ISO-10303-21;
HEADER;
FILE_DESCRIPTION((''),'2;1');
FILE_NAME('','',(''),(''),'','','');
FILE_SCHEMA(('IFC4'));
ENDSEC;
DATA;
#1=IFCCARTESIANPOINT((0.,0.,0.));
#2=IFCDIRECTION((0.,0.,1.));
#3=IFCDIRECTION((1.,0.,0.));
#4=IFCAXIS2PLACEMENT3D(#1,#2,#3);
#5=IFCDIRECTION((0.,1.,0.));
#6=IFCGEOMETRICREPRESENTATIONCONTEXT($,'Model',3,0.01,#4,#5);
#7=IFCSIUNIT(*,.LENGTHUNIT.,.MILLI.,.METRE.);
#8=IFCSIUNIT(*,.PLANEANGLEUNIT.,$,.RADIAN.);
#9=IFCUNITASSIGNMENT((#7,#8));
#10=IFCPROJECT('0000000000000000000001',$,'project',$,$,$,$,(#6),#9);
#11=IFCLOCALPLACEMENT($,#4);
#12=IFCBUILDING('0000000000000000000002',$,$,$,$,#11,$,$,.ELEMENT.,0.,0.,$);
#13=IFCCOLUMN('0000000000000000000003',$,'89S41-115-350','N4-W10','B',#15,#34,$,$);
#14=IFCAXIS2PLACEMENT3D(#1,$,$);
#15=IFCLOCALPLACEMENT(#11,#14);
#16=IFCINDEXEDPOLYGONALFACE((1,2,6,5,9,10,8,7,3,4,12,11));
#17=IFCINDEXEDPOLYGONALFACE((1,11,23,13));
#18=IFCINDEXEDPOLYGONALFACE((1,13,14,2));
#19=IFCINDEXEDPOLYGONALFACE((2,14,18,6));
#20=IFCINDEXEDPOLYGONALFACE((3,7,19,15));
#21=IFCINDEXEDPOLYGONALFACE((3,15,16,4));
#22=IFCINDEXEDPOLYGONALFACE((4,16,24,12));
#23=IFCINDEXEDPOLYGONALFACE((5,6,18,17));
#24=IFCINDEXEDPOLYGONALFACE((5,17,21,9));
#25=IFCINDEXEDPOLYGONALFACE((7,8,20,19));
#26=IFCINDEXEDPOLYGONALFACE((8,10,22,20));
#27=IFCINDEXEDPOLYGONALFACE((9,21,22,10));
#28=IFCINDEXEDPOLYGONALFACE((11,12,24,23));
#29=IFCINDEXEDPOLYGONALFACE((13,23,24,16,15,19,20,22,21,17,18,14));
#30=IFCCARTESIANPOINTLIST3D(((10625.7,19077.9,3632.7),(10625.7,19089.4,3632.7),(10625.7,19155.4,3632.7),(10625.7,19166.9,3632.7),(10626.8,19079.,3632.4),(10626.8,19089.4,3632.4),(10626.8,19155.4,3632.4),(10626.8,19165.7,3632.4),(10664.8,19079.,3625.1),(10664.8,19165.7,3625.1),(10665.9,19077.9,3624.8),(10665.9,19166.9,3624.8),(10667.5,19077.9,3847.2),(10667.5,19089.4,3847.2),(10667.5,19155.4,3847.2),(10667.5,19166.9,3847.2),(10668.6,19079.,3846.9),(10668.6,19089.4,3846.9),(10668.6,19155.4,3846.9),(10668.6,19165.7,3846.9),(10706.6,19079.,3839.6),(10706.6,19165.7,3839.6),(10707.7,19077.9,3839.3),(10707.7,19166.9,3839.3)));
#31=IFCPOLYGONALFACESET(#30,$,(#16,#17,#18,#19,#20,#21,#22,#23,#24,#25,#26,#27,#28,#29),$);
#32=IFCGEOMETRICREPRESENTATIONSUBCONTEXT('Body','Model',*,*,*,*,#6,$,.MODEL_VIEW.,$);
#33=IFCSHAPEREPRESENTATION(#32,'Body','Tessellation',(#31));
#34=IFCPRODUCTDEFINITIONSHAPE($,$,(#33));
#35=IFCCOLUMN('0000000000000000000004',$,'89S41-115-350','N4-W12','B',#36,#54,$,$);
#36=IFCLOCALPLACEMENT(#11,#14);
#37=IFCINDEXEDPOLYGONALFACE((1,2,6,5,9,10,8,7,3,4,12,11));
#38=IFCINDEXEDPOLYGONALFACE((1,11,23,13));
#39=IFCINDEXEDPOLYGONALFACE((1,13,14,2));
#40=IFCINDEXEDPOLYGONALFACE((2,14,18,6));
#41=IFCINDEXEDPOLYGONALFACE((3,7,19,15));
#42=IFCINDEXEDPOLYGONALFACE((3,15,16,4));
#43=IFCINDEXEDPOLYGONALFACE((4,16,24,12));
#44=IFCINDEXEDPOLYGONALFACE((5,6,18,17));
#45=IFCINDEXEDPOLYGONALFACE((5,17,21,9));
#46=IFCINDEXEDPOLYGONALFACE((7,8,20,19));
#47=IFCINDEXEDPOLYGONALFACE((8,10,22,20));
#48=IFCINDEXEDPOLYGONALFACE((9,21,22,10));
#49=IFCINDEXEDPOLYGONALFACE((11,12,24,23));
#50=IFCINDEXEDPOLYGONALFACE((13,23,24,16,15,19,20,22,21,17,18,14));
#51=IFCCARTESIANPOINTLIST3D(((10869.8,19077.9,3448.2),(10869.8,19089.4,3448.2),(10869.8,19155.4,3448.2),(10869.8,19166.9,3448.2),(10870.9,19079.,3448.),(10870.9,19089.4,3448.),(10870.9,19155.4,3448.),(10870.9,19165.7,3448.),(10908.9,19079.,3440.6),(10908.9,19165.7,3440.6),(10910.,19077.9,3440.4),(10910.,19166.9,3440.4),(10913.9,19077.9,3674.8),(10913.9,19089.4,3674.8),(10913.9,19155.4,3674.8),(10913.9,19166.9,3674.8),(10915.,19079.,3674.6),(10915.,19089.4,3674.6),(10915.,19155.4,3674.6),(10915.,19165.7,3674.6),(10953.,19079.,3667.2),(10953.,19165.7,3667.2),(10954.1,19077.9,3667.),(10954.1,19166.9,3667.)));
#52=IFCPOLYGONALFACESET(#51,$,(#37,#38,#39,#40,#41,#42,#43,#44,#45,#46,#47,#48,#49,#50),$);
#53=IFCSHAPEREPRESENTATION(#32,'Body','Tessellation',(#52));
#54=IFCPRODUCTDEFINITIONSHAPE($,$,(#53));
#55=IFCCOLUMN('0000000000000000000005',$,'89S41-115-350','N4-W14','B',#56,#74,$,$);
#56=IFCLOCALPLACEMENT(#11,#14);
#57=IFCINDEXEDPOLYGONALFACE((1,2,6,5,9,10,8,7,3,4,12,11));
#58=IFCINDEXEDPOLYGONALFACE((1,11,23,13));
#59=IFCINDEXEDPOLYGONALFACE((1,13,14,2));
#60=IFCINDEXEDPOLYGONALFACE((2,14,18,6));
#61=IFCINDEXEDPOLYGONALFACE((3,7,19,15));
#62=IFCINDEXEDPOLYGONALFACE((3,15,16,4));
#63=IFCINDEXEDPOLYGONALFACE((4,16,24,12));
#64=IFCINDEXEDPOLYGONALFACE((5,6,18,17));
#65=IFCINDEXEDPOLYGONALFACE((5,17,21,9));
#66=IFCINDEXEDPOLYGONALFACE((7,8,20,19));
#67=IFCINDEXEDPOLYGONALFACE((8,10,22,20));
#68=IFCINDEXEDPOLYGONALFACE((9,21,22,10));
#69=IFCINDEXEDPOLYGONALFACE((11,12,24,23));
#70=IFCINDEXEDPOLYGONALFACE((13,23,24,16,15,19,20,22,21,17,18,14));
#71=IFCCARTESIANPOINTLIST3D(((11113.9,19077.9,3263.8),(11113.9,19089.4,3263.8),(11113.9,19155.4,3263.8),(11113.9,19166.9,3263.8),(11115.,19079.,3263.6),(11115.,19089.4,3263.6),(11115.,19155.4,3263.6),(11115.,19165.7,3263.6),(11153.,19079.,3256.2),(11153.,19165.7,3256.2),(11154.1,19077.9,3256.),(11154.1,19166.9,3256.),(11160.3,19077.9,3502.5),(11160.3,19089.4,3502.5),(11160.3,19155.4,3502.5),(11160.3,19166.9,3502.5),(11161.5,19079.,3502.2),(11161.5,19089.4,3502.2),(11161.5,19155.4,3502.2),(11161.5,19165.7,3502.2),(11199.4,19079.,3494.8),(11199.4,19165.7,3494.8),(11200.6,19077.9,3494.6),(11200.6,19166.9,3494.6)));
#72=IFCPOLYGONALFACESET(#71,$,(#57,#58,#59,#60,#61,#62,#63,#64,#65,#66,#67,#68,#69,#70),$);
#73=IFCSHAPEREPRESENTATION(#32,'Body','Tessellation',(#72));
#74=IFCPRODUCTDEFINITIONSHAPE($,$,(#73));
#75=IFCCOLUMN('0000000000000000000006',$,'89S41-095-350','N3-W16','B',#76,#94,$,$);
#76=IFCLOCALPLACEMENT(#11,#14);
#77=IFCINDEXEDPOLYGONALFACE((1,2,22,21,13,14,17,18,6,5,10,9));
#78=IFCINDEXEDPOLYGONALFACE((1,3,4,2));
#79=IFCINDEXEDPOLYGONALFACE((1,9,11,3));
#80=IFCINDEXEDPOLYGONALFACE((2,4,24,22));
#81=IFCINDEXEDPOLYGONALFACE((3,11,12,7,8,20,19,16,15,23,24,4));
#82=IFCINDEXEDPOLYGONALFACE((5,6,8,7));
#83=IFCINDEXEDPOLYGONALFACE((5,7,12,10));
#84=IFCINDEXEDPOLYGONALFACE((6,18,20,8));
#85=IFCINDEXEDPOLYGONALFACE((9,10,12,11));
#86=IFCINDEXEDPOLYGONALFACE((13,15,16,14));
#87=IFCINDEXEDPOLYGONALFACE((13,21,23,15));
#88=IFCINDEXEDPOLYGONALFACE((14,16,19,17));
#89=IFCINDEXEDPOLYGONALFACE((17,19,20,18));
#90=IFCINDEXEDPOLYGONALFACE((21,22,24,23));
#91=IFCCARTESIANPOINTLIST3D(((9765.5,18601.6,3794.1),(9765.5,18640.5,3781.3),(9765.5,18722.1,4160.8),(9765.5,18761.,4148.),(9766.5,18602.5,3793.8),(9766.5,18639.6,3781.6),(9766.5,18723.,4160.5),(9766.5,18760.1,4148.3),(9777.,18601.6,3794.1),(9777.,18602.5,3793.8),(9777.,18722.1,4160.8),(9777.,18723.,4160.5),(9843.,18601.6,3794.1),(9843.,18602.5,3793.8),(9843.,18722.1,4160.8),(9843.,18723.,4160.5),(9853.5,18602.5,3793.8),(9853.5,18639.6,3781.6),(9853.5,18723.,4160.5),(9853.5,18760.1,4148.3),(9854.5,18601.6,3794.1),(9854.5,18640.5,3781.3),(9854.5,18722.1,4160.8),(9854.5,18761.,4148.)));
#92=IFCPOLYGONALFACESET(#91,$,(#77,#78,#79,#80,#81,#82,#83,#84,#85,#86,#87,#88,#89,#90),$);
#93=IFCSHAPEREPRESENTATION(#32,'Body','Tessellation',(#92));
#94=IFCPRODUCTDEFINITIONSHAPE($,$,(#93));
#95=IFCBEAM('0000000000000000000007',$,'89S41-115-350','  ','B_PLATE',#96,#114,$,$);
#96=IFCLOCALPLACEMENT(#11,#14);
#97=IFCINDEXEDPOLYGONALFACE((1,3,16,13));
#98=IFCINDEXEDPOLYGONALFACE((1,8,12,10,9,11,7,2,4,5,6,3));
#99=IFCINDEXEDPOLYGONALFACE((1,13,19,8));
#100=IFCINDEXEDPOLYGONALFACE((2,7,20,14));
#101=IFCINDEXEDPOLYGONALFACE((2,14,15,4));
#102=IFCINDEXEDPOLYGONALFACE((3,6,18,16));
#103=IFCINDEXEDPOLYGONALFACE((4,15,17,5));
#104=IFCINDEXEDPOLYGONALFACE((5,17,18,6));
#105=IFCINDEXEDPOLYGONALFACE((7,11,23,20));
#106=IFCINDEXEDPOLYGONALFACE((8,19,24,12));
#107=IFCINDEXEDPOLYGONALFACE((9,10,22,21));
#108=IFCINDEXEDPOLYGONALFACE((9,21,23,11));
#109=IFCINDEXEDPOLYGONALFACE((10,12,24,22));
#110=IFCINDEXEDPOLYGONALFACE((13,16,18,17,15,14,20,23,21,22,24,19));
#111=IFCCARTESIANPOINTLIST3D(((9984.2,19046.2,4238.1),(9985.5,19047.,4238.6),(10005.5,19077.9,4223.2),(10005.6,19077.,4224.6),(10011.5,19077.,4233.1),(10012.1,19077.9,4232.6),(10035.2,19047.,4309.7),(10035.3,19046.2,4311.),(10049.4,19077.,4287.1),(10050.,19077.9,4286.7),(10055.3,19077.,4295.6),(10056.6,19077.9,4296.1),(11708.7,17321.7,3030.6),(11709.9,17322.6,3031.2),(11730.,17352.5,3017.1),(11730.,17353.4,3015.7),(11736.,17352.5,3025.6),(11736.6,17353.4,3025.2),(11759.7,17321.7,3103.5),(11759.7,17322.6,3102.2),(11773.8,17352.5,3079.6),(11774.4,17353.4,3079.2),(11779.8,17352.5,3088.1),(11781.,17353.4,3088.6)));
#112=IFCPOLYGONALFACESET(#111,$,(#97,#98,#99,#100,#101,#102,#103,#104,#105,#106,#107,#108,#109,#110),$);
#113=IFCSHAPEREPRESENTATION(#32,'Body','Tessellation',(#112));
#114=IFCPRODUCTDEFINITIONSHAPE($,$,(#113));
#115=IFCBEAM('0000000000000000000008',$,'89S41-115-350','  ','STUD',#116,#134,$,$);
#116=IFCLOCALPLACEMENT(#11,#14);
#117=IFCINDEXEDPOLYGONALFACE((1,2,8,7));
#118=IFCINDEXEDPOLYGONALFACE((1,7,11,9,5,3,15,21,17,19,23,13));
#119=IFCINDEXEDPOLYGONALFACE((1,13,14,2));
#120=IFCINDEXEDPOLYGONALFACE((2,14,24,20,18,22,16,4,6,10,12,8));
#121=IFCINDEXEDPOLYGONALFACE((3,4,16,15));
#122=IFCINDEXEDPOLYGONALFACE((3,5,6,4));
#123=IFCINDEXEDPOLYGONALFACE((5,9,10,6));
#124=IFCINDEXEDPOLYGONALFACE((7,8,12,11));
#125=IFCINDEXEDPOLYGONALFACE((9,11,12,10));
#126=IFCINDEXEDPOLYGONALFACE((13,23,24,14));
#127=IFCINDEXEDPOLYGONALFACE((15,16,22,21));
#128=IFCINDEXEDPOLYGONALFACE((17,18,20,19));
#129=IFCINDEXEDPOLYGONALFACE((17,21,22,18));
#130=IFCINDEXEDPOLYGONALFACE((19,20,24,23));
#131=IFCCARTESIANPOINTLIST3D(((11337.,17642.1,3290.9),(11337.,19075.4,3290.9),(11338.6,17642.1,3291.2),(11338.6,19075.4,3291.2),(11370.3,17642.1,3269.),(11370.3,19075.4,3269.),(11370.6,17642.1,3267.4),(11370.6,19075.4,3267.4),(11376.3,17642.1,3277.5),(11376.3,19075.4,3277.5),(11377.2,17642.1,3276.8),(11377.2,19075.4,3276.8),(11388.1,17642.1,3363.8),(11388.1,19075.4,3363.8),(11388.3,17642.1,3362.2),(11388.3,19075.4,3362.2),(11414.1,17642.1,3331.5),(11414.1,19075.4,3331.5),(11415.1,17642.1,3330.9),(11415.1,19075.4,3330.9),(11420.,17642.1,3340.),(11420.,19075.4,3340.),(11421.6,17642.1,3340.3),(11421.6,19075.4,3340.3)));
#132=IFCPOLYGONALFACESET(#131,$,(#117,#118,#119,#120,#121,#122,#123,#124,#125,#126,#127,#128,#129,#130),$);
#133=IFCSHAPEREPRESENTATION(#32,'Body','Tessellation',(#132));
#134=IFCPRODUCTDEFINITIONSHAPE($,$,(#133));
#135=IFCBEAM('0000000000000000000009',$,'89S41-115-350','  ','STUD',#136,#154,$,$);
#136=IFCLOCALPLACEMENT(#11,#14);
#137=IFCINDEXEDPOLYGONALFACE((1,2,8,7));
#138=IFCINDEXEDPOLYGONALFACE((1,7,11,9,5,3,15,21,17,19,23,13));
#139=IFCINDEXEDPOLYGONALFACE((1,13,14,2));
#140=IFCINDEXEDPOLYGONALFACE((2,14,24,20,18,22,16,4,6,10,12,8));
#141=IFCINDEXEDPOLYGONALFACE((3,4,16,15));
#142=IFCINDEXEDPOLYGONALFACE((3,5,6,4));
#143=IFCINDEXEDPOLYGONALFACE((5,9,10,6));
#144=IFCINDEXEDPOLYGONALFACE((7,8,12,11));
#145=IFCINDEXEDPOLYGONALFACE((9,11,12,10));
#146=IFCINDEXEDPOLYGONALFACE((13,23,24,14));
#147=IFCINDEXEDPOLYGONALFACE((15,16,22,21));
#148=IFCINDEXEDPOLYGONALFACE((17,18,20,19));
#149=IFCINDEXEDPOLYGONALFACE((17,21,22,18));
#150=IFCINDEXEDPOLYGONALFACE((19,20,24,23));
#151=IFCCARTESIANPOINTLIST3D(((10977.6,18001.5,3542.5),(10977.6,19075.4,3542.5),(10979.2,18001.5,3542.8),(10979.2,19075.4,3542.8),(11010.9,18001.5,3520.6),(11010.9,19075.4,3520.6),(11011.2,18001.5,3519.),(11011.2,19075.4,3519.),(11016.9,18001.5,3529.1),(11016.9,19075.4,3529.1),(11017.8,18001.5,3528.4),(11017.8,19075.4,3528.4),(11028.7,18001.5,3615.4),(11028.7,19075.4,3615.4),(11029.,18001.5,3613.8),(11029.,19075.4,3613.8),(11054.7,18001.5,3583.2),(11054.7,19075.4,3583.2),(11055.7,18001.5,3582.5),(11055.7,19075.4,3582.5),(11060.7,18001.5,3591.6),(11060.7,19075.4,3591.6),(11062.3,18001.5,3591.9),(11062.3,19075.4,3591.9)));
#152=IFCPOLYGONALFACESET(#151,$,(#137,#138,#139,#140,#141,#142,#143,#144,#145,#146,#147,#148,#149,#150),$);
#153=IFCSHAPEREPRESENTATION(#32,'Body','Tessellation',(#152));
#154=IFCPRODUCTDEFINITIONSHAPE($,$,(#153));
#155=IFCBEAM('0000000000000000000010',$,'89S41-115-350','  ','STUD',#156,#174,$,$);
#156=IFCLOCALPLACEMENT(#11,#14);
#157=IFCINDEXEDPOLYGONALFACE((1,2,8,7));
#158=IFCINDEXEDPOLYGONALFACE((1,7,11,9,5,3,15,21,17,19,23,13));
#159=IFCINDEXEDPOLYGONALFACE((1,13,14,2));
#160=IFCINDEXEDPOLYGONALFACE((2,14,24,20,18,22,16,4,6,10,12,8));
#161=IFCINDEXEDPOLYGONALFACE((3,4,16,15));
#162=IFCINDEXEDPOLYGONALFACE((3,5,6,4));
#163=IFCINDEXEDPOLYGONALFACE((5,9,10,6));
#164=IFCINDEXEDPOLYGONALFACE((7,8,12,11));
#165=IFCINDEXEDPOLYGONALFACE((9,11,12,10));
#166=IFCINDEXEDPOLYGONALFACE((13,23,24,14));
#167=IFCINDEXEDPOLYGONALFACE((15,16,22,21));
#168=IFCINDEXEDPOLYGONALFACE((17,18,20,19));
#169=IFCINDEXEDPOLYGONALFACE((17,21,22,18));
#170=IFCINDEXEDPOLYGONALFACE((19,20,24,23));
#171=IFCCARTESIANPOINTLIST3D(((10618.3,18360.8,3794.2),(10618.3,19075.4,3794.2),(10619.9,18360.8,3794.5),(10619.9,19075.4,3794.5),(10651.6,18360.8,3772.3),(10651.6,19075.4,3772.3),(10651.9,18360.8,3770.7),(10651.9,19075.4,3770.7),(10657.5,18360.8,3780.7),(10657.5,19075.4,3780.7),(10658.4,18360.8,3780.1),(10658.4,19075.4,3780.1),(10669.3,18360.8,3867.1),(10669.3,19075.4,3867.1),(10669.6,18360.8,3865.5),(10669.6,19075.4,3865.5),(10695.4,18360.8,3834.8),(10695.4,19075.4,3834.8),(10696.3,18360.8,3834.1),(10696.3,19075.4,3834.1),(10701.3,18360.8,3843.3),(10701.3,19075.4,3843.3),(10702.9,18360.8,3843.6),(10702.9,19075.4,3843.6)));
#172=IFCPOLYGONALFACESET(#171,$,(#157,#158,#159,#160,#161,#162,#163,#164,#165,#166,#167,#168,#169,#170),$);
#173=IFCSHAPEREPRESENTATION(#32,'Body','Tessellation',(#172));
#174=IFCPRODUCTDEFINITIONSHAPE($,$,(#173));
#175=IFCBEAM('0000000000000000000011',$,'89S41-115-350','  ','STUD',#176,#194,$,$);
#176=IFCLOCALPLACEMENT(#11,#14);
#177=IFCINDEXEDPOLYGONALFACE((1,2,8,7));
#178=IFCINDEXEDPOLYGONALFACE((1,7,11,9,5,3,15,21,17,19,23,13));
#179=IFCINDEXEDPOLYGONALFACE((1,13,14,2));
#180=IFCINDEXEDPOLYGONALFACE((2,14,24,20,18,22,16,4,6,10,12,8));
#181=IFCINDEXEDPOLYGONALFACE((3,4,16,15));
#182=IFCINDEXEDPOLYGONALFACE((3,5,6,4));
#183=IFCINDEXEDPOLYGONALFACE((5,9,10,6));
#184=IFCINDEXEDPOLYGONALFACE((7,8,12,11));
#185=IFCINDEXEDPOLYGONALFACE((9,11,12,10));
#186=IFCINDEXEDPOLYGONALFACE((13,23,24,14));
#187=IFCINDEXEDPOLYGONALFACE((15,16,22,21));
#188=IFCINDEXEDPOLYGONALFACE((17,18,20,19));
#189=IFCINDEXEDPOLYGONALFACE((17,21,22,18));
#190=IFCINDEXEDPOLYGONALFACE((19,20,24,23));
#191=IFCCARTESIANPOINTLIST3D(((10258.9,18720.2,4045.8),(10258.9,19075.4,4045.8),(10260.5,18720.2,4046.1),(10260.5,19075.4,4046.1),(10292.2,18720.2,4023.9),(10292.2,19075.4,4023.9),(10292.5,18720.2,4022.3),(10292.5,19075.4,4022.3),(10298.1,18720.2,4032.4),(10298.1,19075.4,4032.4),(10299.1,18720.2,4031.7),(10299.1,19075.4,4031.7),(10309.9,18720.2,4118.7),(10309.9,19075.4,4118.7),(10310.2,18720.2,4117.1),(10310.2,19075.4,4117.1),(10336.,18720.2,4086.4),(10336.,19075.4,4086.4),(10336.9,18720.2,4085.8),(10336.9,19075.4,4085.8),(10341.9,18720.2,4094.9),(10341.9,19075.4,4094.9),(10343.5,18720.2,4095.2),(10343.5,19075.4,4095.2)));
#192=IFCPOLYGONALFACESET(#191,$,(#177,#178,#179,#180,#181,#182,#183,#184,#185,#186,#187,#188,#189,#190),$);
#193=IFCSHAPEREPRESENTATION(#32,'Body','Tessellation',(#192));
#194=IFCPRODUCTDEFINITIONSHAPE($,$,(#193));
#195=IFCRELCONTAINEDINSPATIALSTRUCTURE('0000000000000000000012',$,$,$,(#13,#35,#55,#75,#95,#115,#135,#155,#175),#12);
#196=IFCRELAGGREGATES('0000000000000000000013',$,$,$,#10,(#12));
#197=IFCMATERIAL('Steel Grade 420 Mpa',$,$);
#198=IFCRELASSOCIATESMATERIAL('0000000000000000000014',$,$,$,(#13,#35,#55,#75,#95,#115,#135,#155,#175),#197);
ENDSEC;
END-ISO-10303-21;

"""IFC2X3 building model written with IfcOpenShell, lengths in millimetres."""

from ifc_helpers import new_model, si_unit, direction, frame, origin, origin_with_axes, origin_2d_with_axis, place, context, subcontext, project, spatial, c_section, extrude, source, transform, mapped, material, element, save


model = new_model("IFC2X3")

# Units and contexts
model_context = context("Model", 3, precision=0.01, world=origin_with_axes(), true_north=direction((0.0, 1.0, 0.0)))
body_context = subcontext(model_context, "Body", "Model", "MODEL_VIEW")
ifc_project = project(units=[si_unit("LENGTHUNIT", "METRE", prefix="MILLI"), si_unit("PLANEANGLEUNIT", "RADIAN")], contexts=[model_context])

# Building
building_placement = place(None, origin_with_axes())
building = spatial("IfcBuilding", under=ifc_project, at=building_placement, CompositionType="ELEMENT", ElevationOfRefHeight=0.0, ElevationOfTerrain=0.0)

# Columns
ifc_material = material(Name="Steel Grade 420 Mpa")
shared_shape_1 = source(origin(), body_context, "Body", "SweptSolid", [
    extrude(c_section(Depth=89.0, Width=41.0, WallThickness=1.1, Girth=11.5, at=origin_2d_with_axis()), origin_with_axes(), (0.0, 0.0, 1.0), 218.5),
])
column_1_placement = place(None, frame((10645.8, 19122.4, 3628.8), z_axis=(0.191063, 0.0, 0.981578), x_axis=(-0.981578, 0.0, 0.191063)))
element("IfcColumn", 1, at=column_1_placement, inside=building, material=ifc_material, Name="89S41-115-350", Description="N4-W10", ObjectType="B", context=body_context, shape_type="MappedRepresentation", body=[
    mapped(shared_shape_1, transform((0.0, 0.0, 0.0), scale=1.0)),
])
shared_shape_2 = source(origin(), body_context, "Body", "SweptSolid", [
    extrude(c_section(Depth=89.0, Width=41.0, WallThickness=1.1, Girth=11.5, at=origin_2d_with_axis()), origin_with_axes(), (0.0, 0.0, 1.0), 230.8),
])
column_2_placement = place(None, frame((10889.9, 19122.4, 3444.3), z_axis=(0.191063, 0.0, 0.981578), x_axis=(-0.981578, 0.0, 0.191063)))
element("IfcColumn", 2, at=column_2_placement, inside=building, material=ifc_material, Name="89S41-115-350", Description="N4-W12", ObjectType="B", context=body_context, shape_type="MappedRepresentation", body=[
    mapped(shared_shape_2, transform((0.0, 0.0, 0.0), scale=1.0)),
])
shared_shape_3 = source(origin(), body_context, "Body", "SweptSolid", [
    extrude(c_section(Depth=89.0, Width=41.0, WallThickness=1.1, Girth=11.5, at=origin_2d_with_axis()), origin_with_axes(), (0.0, 0.0, 1.0), 243.1),
])
column_3_placement = place(None, frame((11134.0, 19122.4, 3259.9), z_axis=(0.191063, 0.0, 0.981578), x_axis=(-0.981578, 0.0, 0.191063)))
element("IfcColumn", 3, at=column_3_placement, inside=building, material=ifc_material, Name="89S41-115-350", Description="N4-W14", ObjectType="B", context=body_context, shape_type="MappedRepresentation", body=[
    mapped(shared_shape_3, transform((0.0, 0.0, 0.0), scale=1.0)),
])
shared_shape_4 = source(origin(), body_context, "Body", "SweptSolid", [
    extrude(c_section(Depth=89.0, Width=41.0, WallThickness=1.0, Girth=11.5, at=origin_2d_with_axis()), origin_with_axes(), (0.0, 0.0, 1.0), 385.9),
])
column_4_placement = place(None, frame((9810.0, 18741.5, 4154.4), z_axis=(0.0, -0.312196, -0.950018), x_axis=(0.0, -0.950018, 0.312196)))
element("IfcColumn", 4, at=column_4_placement, inside=building, material=ifc_material, Name="89S41-095-350", Description="N3-W16", ObjectType="B", context=body_context, shape_type="MappedRepresentation", body=[
    mapped(shared_shape_4, transform((0.0, 0.0, 0.0), scale=1.0)),
])

# Beams
shared_shape_5 = source(origin(), body_context, "Body", "SweptSolid", [
    extrude(c_section(Depth=89.0, Width=41.0, WallThickness=1.1, Girth=11.5, at=origin_2d_with_axis()), origin_with_axes(), (0.0, 0.0, 1.0), 2721.3),
])
beam_1_placement = place(None, frame((10020.4, 19062.0, 4267.1), z_axis=(0.633687, -0.633687, -0.443713), x_axis=(0.519086, 0.773589, -0.363468)))
element("IfcBeam", 5, at=beam_1_placement, inside=building, material=ifc_material, Name="89S41-115-350", Description="  ", ObjectType="B_PLATE", context=body_context, shape_type="MappedRepresentation", body=[
    mapped(shared_shape_5, transform((0.0, 0.0, 0.0), scale=1.0)),
])
shared_shape_6 = source(origin(), body_context, "Body", "SweptSolid", [
    extrude(c_section(Depth=89.0, Width=41.0, WallThickness=1.1, Girth=11.5, at=origin_2d_with_axis()), origin_with_axes(), (0.0, 0.0, 1.0), 1433.3),
])
beam_2_placement = place(None, frame((11379.3, 17642.1, 3315.6), z_axis=(0.0, 1.0, 0.0), x_axis=(0.819152, 0.0, -0.573576)))
element("IfcBeam", 6, at=beam_2_placement, inside=building, material=ifc_material, Name="89S41-115-350", Description="  ", ObjectType="STUD", context=body_context, shape_type="MappedRepresentation", body=[
    mapped(shared_shape_6, transform((0.0, 0.0, 0.0), scale=1.0)),
])
shared_shape_7 = source(origin(), body_context, "Body", "SweptSolid", [
    extrude(c_section(Depth=89.0, Width=41.0, WallThickness=1.1, Girth=11.5, at=origin_2d_with_axis()), origin_with_axes(), (0.0, 0.0, 1.0), 1073.9),
])
beam_3_placement = place(None, frame((11020.0, 18001.5, 3567.2), z_axis=(0.0, 1.0, 0.0), x_axis=(0.819152, 0.0, -0.573576)))
element("IfcBeam", 7, at=beam_3_placement, inside=building, material=ifc_material, Name="89S41-115-350", Description="  ", ObjectType="STUD", context=body_context, shape_type="MappedRepresentation", body=[
    mapped(shared_shape_7, transform((0.0, 0.0, 0.0), scale=1.0)),
])
shared_shape_8 = source(origin(), body_context, "Body", "SweptSolid", [
    extrude(c_section(Depth=89.0, Width=41.0, WallThickness=1.1, Girth=11.5, at=origin_2d_with_axis()), origin_with_axes(), (0.0, 0.0, 1.0), 714.5),
])
beam_4_placement = place(None, frame((10660.6, 18360.8, 3818.9), z_axis=(0.0, 1.0, 0.0), x_axis=(0.819152, 0.0, -0.573576)))
element("IfcBeam", 8, at=beam_4_placement, inside=building, material=ifc_material, Name="89S41-115-350", Description="  ", ObjectType="STUD", context=body_context, shape_type="MappedRepresentation", body=[
    mapped(shared_shape_8, transform((0.0, 0.0, 0.0), scale=1.0)),
])
shared_shape_9 = source(origin(), body_context, "Body", "SweptSolid", [
    extrude(c_section(Depth=89.0, Width=41.0, WallThickness=1.1, Girth=11.5, at=origin_2d_with_axis()), origin_with_axes(), (0.0, 0.0, 1.0), 355.2),
])
beam_5_placement = place(None, frame((10301.2, 18720.2, 4070.5), z_axis=(0.0, 1.0, 0.0), x_axis=(0.819152, 0.0, -0.573576)))
element("IfcBeam", 9, at=beam_5_placement, inside=building, material=ifc_material, Name="89S41-115-350", Description="  ", ObjectType="STUD", context=body_context, shape_type="MappedRepresentation", body=[
    mapped(shared_shape_9, transform((0.0, 0.0, 0.0), scale=1.0)),
])

save(model, "model.ifc")
